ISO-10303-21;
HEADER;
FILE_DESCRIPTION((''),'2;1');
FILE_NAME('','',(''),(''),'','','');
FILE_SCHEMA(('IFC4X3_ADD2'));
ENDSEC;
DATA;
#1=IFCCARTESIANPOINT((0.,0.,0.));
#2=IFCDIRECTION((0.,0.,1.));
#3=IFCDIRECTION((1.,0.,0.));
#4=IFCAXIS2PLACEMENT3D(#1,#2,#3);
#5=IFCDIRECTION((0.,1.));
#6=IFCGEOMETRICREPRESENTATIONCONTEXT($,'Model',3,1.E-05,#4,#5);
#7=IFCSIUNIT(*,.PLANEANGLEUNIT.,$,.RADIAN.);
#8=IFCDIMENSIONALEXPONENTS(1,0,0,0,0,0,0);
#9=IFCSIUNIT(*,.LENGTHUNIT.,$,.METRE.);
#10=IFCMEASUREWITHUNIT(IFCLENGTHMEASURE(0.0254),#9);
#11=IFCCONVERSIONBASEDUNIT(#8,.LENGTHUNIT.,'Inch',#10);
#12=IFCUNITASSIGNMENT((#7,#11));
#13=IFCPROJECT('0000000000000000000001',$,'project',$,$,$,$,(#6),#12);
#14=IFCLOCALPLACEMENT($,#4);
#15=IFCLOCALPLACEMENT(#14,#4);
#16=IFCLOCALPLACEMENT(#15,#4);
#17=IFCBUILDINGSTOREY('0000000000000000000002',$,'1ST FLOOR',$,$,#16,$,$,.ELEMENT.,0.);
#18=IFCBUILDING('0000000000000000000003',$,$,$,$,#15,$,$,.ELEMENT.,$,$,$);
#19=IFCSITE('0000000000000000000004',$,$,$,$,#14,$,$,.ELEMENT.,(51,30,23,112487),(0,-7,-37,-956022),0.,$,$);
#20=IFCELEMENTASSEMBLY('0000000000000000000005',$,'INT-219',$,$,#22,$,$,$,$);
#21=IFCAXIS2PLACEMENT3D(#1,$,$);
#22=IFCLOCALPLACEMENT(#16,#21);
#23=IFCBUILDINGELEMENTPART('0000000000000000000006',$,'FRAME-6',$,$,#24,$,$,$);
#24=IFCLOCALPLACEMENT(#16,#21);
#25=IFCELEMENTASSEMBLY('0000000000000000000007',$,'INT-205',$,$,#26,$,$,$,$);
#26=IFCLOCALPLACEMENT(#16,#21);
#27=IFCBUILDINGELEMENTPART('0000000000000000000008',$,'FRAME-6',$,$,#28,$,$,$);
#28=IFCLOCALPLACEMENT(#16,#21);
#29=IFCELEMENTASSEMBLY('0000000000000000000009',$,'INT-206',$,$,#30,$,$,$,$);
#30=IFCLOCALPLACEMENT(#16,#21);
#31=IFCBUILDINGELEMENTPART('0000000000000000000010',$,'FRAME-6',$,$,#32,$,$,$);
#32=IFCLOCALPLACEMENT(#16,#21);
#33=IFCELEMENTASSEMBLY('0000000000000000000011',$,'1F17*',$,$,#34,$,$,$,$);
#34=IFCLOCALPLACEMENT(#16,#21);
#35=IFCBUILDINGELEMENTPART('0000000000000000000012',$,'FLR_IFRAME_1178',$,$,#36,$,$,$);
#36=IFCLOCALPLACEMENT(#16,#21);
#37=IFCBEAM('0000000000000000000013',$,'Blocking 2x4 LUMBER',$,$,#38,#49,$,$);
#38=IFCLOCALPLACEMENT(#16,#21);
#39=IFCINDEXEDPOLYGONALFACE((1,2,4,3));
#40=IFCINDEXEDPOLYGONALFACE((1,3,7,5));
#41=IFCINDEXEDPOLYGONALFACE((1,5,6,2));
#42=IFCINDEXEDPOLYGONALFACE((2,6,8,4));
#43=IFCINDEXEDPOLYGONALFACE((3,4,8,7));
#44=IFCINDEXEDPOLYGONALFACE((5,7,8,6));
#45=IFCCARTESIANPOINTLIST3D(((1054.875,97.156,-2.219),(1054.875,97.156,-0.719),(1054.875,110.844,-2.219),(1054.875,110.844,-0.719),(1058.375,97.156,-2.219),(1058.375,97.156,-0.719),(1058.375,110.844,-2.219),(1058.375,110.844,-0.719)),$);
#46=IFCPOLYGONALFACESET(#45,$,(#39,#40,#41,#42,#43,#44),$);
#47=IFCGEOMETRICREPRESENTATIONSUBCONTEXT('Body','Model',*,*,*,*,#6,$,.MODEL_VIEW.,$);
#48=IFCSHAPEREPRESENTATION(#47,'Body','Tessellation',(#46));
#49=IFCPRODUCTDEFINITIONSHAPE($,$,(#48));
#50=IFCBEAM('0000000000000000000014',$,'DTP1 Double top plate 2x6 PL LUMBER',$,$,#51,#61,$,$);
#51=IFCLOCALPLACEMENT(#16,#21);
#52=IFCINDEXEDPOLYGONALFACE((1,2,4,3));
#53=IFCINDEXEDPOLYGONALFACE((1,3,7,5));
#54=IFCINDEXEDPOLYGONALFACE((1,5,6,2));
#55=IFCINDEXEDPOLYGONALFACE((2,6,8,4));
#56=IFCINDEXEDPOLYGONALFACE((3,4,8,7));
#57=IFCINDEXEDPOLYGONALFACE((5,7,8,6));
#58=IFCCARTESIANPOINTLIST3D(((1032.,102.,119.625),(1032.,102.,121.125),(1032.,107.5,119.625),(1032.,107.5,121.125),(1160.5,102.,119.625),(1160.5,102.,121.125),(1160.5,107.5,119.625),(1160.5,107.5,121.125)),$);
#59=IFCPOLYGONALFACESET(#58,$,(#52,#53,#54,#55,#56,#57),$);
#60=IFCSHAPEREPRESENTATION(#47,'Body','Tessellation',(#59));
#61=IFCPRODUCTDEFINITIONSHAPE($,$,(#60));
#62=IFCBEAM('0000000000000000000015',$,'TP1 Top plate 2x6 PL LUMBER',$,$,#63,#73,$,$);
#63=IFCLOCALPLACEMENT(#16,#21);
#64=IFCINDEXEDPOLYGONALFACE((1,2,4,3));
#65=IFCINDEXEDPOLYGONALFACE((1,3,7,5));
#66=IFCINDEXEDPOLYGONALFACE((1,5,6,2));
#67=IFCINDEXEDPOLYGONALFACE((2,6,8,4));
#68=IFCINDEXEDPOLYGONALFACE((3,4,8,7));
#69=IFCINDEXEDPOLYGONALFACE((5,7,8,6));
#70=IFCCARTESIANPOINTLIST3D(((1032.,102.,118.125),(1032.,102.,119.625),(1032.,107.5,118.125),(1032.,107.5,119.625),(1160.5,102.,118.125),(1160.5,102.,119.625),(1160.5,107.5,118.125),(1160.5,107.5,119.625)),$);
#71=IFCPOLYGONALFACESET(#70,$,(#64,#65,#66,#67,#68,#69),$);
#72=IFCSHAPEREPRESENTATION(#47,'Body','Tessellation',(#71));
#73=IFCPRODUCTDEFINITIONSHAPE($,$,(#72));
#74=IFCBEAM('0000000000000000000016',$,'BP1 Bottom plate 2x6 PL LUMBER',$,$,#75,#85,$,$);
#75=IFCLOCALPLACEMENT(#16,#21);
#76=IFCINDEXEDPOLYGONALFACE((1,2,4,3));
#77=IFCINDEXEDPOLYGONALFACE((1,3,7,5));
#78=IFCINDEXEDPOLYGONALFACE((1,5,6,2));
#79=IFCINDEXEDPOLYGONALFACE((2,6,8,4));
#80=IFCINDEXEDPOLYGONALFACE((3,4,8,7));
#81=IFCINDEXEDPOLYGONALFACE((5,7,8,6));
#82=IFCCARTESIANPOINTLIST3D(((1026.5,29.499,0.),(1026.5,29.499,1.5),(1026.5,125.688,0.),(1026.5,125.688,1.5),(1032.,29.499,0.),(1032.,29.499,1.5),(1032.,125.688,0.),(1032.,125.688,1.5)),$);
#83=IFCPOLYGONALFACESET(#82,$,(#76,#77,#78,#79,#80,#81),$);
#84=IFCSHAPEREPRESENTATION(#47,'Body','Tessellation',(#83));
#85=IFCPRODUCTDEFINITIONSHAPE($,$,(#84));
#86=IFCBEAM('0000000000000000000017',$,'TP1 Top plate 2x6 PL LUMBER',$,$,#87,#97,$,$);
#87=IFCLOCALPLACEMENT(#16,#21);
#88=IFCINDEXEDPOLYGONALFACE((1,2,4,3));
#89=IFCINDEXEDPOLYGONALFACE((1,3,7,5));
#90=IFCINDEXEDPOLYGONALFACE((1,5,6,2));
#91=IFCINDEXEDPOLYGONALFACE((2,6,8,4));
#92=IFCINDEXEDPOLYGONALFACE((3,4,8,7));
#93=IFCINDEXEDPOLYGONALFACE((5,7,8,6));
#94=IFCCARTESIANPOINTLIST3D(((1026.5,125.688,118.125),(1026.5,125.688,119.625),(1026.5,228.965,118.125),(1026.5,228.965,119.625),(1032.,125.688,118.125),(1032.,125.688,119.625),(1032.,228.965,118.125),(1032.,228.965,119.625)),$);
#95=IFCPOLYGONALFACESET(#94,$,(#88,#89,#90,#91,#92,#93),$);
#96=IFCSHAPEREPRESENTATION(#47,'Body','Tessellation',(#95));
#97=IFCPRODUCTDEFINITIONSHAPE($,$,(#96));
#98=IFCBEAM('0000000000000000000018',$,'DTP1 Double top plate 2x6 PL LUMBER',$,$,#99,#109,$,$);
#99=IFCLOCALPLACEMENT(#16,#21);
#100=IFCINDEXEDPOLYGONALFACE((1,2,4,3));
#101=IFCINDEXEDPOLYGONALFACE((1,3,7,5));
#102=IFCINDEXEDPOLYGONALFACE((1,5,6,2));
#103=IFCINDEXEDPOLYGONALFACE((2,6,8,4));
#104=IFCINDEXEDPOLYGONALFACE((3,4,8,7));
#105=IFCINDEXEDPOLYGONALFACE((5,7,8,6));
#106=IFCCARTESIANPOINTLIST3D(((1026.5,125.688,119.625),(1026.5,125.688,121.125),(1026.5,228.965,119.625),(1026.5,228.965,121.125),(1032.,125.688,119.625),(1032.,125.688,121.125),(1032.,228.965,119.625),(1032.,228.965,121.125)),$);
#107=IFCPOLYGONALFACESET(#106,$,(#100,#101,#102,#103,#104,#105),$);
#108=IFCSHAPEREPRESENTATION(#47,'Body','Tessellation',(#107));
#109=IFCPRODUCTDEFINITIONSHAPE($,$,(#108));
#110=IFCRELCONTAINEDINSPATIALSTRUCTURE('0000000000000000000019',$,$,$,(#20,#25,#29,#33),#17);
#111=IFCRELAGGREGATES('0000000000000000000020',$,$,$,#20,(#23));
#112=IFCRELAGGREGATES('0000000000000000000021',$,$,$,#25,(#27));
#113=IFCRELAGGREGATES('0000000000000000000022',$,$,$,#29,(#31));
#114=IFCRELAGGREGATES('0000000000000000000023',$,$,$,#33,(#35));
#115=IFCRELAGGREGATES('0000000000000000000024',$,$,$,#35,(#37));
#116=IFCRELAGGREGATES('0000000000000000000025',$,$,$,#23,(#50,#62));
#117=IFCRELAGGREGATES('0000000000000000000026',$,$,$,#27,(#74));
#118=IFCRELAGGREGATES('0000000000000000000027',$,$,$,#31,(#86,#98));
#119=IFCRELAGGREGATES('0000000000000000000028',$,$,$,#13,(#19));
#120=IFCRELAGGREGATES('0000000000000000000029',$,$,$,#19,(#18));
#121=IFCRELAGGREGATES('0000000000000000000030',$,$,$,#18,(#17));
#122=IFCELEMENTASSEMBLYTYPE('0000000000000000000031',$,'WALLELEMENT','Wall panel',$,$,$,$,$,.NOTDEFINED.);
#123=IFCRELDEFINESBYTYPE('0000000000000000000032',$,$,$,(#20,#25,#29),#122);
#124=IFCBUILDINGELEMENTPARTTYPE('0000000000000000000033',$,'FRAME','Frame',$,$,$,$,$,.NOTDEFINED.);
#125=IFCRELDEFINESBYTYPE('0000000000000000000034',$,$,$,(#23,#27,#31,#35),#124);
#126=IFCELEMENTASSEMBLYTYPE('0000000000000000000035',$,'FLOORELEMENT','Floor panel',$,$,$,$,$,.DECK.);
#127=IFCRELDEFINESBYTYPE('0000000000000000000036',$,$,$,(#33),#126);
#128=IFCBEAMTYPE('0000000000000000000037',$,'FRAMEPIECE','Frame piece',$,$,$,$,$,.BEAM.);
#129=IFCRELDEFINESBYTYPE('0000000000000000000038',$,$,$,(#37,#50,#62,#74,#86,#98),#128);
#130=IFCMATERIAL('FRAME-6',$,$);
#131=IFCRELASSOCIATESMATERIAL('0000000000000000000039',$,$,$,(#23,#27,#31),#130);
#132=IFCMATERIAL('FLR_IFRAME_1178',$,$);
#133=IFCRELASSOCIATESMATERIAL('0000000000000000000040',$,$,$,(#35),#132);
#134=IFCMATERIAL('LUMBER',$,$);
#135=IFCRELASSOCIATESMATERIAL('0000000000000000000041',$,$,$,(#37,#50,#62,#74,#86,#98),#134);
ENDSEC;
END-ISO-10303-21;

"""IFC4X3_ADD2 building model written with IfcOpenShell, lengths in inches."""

from ifc_helpers import new_model, entity, si_unit, converted_unit, direction, frame, origin_with_axes, origin_2d_with_axis, place, context, subcontext, project, spatial, rectangle, extrude, material, type_object, element, aggregate, save


model = new_model("IFC4X3_ADD2")

# Units and contexts
model_context = context("Model", 3, precision=1e-05, world=origin_with_axes(), true_north=direction((0.0, 1.0)))
body_context = subcontext(model_context, "Body", "Model", "MODEL_VIEW")
ifc_project = project(units=[si_unit("PLANEANGLEUNIT", "RADIAN"), converted_unit("LENGTHUNIT", "Inch", entity("IfcLengthMeasure", 0.0254), si_unit("LENGTHUNIT", "METRE"), dimensions=[1, 0, 0, 0, 0, 0, 0])], contexts=[model_context])

# Site, building, storey
site_placement = place(None, origin_with_axes())
site = spatial("IfcSite", under=ifc_project, at=site_placement, CompositionType="ELEMENT", RefLatitude=(51, 30, 23, 112487), RefLongitude=(0, -7, -37, -956022), RefElevation=0.0)
building_placement = place(site_placement, origin_with_axes())
building = spatial("IfcBuilding", under=site, at=building_placement, CompositionType="ELEMENT")
storey_placement = place(building_placement, origin_with_axes())
storey = spatial("IfcBuildingStorey", under=building, at=storey_placement, Name="1ST FLOOR", CompositionType="ELEMENT", Elevation=0.0)

# Element assemblies, building element parts
element_assembly_type_1 = type_object("IfcElementAssemblyType", Name="WALLELEMENT", Description="Wall panel", PredefinedType="NOTDEFINED")
assembly_1_placement = place(storey_placement, origin_with_axes())
assembly_1 = element("IfcElementAssembly", 1, at=assembly_1_placement, inside=storey, type_object=element_assembly_type_1, Name="INT-219")
ifc_material_1 = material(Name="FRAME-6")
building_element_part_type = type_object("IfcBuildingElementPartType", Name="FRAME", Description="Frame", PredefinedType="NOTDEFINED")
building_element_part_1_placement = place(storey_placement, origin_with_axes())
building_element_part_1 = element("IfcBuildingElementPart", 2, at=building_element_part_1_placement, type_object=building_element_part_type, material=ifc_material_1, Name="FRAME-6")
aggregate(assembly_1, [building_element_part_1])
ifc_material_2 = material(Name="LUMBER")
assembly_2_placement = place(storey_placement, origin_with_axes())
assembly_2 = element("IfcElementAssembly", 3, at=assembly_2_placement, inside=storey, type_object=element_assembly_type_1, Name="INT-205")
building_element_part_2_placement = place(storey_placement, origin_with_axes())
building_element_part_2 = element("IfcBuildingElementPart", 4, at=building_element_part_2_placement, type_object=building_element_part_type, material=ifc_material_1, Name="FRAME-6")
aggregate(assembly_2, [building_element_part_2])
assembly_3_placement = place(storey_placement, origin_with_axes())
assembly_3 = element("IfcElementAssembly", 5, at=assembly_3_placement, inside=storey, type_object=element_assembly_type_1, Name="INT-206")
building_element_part_3_placement = place(storey_placement, origin_with_axes())
building_element_part_3 = element("IfcBuildingElementPart", 6, at=building_element_part_3_placement, type_object=building_element_part_type, material=ifc_material_1, Name="FRAME-6")
aggregate(assembly_3, [building_element_part_3])

# Element assembly, building element part, beam
element_assembly_type_2 = type_object("IfcElementAssemblyType", Name="FLOORELEMENT", Description="Floor panel", PredefinedType="DECK")
assembly_4_placement = place(storey_placement, origin_with_axes())
assembly_4 = element("IfcElementAssembly", 7, at=assembly_4_placement, inside=storey, type_object=element_assembly_type_2, Name="1F17*")
ifc_material_3 = material(Name="FLR_IFRAME_1178")
building_element_part_4_placement = place(storey_placement, origin_with_axes())
building_element_part_4 = element("IfcBuildingElementPart", 8, at=building_element_part_4_placement, type_object=building_element_part_type, material=ifc_material_3, Name="FLR_IFRAME_1178")
aggregate(assembly_4, [building_element_part_4])
beam_type = type_object("IfcBeamType", Name="FRAMEPIECE", Description="Frame piece", PredefinedType="BEAM")
beam_1_placement = place(storey_placement, frame((1056.625, 110.844, -1.469), z_axis=(0.0, -1.0, 0.0), x_axis=(0.0, 0.0, 1.0)))
beam_1 = element("IfcBeam", 9, at=beam_1_placement, type_object=beam_type, material=ifc_material_2, Name="Blocking 2x4 LUMBER", context=body_context, shape_type="SweptSolid", body=[
    extrude(rectangle(XDim=1.5, YDim=3.5, at=origin_2d_with_axis()), origin_with_axes(), (0.0, 0.0, 1.0), 13.687),
])
aggregate(building_element_part_4, [beam_1])

# Beams
beam_2_placement = place(storey_placement, frame((1032.0, 104.75, 120.375), z_axis=(1.0, 0.0, 0.0), x_axis=(0.0, 0.0, -1.0)))
beam_2 = element("IfcBeam", 10, at=beam_2_placement, type_object=beam_type, material=ifc_material_2, Name="DTP1 Double top plate 2x6 PL LUMBER", context=body_context, shape_type="SweptSolid", body=[
    extrude(rectangle(XDim=1.5, YDim=5.5, at=origin_2d_with_axis()), origin_with_axes(), (0.0, 0.0, 1.0), 128.5),
])
beam_3_placement = place(storey_placement, frame((1032.0, 104.75, 118.875), z_axis=(1.0, 0.0, 0.0), x_axis=(0.0, 0.0, -1.0)))
beam_3 = element("IfcBeam", 11, at=beam_3_placement, type_object=beam_type, material=ifc_material_2, Name="TP1 Top plate 2x6 PL LUMBER", context=body_context, shape_type="SweptSolid", body=[
    extrude(rectangle(XDim=1.5, YDim=5.5, at=origin_2d_with_axis()), origin_with_axes(), (0.0, 0.0, 1.0), 128.5),
])
aggregate(building_element_part_1, [beam_2, beam_3])
beam_4_placement = place(storey_placement, frame((1029.25, 125.688, 0.75), z_axis=(0.0, -1.0, 0.0), x_axis=(0.0, 0.0, 1.0)))
beam_4 = element("IfcBeam", 12, at=beam_4_placement, type_object=beam_type, material=ifc_material_2, Name="BP1 Bottom plate 2x6 PL LUMBER", context=body_context, shape_type="SweptSolid", body=[
    extrude(rectangle(XDim=1.5, YDim=5.5, at=origin_2d_with_axis()), origin_with_axes(), (0.0, 0.0, 1.0), 96.188),
])
aggregate(building_element_part_2, [beam_4])
beam_5_placement = place(storey_placement, frame((1029.25, 125.688, 118.875), z_axis=(0.0, 1.0, 0.0), x_axis=(0.0, 0.0, -1.0)))
beam_5 = element("IfcBeam", 13, at=beam_5_placement, type_object=beam_type, material=ifc_material_2, Name="TP1 Top plate 2x6 PL LUMBER", context=body_context, shape_type="SweptSolid", body=[
    extrude(rectangle(XDim=1.5, YDim=5.5, at=origin_2d_with_axis()), origin_with_axes(), (0.0, 0.0, 1.0), 103.277),
])
beam_6_placement = place(storey_placement, frame((1029.25, 125.688, 120.375), z_axis=(0.0, 1.0, 0.0), x_axis=(0.0, 0.0, -1.0)))
beam_6 = element("IfcBeam", 14, at=beam_6_placement, type_object=beam_type, material=ifc_material_2, Name="DTP1 Double top plate 2x6 PL LUMBER", context=body_context, shape_type="SweptSolid", body=[
    extrude(rectangle(XDim=1.5, YDim=5.5, at=origin_2d_with_axis()), origin_with_axes(), (0.0, 0.0, 1.0), 103.277),
])
aggregate(building_element_part_3, [beam_5, beam_6])

save(model, "model.ifc")
